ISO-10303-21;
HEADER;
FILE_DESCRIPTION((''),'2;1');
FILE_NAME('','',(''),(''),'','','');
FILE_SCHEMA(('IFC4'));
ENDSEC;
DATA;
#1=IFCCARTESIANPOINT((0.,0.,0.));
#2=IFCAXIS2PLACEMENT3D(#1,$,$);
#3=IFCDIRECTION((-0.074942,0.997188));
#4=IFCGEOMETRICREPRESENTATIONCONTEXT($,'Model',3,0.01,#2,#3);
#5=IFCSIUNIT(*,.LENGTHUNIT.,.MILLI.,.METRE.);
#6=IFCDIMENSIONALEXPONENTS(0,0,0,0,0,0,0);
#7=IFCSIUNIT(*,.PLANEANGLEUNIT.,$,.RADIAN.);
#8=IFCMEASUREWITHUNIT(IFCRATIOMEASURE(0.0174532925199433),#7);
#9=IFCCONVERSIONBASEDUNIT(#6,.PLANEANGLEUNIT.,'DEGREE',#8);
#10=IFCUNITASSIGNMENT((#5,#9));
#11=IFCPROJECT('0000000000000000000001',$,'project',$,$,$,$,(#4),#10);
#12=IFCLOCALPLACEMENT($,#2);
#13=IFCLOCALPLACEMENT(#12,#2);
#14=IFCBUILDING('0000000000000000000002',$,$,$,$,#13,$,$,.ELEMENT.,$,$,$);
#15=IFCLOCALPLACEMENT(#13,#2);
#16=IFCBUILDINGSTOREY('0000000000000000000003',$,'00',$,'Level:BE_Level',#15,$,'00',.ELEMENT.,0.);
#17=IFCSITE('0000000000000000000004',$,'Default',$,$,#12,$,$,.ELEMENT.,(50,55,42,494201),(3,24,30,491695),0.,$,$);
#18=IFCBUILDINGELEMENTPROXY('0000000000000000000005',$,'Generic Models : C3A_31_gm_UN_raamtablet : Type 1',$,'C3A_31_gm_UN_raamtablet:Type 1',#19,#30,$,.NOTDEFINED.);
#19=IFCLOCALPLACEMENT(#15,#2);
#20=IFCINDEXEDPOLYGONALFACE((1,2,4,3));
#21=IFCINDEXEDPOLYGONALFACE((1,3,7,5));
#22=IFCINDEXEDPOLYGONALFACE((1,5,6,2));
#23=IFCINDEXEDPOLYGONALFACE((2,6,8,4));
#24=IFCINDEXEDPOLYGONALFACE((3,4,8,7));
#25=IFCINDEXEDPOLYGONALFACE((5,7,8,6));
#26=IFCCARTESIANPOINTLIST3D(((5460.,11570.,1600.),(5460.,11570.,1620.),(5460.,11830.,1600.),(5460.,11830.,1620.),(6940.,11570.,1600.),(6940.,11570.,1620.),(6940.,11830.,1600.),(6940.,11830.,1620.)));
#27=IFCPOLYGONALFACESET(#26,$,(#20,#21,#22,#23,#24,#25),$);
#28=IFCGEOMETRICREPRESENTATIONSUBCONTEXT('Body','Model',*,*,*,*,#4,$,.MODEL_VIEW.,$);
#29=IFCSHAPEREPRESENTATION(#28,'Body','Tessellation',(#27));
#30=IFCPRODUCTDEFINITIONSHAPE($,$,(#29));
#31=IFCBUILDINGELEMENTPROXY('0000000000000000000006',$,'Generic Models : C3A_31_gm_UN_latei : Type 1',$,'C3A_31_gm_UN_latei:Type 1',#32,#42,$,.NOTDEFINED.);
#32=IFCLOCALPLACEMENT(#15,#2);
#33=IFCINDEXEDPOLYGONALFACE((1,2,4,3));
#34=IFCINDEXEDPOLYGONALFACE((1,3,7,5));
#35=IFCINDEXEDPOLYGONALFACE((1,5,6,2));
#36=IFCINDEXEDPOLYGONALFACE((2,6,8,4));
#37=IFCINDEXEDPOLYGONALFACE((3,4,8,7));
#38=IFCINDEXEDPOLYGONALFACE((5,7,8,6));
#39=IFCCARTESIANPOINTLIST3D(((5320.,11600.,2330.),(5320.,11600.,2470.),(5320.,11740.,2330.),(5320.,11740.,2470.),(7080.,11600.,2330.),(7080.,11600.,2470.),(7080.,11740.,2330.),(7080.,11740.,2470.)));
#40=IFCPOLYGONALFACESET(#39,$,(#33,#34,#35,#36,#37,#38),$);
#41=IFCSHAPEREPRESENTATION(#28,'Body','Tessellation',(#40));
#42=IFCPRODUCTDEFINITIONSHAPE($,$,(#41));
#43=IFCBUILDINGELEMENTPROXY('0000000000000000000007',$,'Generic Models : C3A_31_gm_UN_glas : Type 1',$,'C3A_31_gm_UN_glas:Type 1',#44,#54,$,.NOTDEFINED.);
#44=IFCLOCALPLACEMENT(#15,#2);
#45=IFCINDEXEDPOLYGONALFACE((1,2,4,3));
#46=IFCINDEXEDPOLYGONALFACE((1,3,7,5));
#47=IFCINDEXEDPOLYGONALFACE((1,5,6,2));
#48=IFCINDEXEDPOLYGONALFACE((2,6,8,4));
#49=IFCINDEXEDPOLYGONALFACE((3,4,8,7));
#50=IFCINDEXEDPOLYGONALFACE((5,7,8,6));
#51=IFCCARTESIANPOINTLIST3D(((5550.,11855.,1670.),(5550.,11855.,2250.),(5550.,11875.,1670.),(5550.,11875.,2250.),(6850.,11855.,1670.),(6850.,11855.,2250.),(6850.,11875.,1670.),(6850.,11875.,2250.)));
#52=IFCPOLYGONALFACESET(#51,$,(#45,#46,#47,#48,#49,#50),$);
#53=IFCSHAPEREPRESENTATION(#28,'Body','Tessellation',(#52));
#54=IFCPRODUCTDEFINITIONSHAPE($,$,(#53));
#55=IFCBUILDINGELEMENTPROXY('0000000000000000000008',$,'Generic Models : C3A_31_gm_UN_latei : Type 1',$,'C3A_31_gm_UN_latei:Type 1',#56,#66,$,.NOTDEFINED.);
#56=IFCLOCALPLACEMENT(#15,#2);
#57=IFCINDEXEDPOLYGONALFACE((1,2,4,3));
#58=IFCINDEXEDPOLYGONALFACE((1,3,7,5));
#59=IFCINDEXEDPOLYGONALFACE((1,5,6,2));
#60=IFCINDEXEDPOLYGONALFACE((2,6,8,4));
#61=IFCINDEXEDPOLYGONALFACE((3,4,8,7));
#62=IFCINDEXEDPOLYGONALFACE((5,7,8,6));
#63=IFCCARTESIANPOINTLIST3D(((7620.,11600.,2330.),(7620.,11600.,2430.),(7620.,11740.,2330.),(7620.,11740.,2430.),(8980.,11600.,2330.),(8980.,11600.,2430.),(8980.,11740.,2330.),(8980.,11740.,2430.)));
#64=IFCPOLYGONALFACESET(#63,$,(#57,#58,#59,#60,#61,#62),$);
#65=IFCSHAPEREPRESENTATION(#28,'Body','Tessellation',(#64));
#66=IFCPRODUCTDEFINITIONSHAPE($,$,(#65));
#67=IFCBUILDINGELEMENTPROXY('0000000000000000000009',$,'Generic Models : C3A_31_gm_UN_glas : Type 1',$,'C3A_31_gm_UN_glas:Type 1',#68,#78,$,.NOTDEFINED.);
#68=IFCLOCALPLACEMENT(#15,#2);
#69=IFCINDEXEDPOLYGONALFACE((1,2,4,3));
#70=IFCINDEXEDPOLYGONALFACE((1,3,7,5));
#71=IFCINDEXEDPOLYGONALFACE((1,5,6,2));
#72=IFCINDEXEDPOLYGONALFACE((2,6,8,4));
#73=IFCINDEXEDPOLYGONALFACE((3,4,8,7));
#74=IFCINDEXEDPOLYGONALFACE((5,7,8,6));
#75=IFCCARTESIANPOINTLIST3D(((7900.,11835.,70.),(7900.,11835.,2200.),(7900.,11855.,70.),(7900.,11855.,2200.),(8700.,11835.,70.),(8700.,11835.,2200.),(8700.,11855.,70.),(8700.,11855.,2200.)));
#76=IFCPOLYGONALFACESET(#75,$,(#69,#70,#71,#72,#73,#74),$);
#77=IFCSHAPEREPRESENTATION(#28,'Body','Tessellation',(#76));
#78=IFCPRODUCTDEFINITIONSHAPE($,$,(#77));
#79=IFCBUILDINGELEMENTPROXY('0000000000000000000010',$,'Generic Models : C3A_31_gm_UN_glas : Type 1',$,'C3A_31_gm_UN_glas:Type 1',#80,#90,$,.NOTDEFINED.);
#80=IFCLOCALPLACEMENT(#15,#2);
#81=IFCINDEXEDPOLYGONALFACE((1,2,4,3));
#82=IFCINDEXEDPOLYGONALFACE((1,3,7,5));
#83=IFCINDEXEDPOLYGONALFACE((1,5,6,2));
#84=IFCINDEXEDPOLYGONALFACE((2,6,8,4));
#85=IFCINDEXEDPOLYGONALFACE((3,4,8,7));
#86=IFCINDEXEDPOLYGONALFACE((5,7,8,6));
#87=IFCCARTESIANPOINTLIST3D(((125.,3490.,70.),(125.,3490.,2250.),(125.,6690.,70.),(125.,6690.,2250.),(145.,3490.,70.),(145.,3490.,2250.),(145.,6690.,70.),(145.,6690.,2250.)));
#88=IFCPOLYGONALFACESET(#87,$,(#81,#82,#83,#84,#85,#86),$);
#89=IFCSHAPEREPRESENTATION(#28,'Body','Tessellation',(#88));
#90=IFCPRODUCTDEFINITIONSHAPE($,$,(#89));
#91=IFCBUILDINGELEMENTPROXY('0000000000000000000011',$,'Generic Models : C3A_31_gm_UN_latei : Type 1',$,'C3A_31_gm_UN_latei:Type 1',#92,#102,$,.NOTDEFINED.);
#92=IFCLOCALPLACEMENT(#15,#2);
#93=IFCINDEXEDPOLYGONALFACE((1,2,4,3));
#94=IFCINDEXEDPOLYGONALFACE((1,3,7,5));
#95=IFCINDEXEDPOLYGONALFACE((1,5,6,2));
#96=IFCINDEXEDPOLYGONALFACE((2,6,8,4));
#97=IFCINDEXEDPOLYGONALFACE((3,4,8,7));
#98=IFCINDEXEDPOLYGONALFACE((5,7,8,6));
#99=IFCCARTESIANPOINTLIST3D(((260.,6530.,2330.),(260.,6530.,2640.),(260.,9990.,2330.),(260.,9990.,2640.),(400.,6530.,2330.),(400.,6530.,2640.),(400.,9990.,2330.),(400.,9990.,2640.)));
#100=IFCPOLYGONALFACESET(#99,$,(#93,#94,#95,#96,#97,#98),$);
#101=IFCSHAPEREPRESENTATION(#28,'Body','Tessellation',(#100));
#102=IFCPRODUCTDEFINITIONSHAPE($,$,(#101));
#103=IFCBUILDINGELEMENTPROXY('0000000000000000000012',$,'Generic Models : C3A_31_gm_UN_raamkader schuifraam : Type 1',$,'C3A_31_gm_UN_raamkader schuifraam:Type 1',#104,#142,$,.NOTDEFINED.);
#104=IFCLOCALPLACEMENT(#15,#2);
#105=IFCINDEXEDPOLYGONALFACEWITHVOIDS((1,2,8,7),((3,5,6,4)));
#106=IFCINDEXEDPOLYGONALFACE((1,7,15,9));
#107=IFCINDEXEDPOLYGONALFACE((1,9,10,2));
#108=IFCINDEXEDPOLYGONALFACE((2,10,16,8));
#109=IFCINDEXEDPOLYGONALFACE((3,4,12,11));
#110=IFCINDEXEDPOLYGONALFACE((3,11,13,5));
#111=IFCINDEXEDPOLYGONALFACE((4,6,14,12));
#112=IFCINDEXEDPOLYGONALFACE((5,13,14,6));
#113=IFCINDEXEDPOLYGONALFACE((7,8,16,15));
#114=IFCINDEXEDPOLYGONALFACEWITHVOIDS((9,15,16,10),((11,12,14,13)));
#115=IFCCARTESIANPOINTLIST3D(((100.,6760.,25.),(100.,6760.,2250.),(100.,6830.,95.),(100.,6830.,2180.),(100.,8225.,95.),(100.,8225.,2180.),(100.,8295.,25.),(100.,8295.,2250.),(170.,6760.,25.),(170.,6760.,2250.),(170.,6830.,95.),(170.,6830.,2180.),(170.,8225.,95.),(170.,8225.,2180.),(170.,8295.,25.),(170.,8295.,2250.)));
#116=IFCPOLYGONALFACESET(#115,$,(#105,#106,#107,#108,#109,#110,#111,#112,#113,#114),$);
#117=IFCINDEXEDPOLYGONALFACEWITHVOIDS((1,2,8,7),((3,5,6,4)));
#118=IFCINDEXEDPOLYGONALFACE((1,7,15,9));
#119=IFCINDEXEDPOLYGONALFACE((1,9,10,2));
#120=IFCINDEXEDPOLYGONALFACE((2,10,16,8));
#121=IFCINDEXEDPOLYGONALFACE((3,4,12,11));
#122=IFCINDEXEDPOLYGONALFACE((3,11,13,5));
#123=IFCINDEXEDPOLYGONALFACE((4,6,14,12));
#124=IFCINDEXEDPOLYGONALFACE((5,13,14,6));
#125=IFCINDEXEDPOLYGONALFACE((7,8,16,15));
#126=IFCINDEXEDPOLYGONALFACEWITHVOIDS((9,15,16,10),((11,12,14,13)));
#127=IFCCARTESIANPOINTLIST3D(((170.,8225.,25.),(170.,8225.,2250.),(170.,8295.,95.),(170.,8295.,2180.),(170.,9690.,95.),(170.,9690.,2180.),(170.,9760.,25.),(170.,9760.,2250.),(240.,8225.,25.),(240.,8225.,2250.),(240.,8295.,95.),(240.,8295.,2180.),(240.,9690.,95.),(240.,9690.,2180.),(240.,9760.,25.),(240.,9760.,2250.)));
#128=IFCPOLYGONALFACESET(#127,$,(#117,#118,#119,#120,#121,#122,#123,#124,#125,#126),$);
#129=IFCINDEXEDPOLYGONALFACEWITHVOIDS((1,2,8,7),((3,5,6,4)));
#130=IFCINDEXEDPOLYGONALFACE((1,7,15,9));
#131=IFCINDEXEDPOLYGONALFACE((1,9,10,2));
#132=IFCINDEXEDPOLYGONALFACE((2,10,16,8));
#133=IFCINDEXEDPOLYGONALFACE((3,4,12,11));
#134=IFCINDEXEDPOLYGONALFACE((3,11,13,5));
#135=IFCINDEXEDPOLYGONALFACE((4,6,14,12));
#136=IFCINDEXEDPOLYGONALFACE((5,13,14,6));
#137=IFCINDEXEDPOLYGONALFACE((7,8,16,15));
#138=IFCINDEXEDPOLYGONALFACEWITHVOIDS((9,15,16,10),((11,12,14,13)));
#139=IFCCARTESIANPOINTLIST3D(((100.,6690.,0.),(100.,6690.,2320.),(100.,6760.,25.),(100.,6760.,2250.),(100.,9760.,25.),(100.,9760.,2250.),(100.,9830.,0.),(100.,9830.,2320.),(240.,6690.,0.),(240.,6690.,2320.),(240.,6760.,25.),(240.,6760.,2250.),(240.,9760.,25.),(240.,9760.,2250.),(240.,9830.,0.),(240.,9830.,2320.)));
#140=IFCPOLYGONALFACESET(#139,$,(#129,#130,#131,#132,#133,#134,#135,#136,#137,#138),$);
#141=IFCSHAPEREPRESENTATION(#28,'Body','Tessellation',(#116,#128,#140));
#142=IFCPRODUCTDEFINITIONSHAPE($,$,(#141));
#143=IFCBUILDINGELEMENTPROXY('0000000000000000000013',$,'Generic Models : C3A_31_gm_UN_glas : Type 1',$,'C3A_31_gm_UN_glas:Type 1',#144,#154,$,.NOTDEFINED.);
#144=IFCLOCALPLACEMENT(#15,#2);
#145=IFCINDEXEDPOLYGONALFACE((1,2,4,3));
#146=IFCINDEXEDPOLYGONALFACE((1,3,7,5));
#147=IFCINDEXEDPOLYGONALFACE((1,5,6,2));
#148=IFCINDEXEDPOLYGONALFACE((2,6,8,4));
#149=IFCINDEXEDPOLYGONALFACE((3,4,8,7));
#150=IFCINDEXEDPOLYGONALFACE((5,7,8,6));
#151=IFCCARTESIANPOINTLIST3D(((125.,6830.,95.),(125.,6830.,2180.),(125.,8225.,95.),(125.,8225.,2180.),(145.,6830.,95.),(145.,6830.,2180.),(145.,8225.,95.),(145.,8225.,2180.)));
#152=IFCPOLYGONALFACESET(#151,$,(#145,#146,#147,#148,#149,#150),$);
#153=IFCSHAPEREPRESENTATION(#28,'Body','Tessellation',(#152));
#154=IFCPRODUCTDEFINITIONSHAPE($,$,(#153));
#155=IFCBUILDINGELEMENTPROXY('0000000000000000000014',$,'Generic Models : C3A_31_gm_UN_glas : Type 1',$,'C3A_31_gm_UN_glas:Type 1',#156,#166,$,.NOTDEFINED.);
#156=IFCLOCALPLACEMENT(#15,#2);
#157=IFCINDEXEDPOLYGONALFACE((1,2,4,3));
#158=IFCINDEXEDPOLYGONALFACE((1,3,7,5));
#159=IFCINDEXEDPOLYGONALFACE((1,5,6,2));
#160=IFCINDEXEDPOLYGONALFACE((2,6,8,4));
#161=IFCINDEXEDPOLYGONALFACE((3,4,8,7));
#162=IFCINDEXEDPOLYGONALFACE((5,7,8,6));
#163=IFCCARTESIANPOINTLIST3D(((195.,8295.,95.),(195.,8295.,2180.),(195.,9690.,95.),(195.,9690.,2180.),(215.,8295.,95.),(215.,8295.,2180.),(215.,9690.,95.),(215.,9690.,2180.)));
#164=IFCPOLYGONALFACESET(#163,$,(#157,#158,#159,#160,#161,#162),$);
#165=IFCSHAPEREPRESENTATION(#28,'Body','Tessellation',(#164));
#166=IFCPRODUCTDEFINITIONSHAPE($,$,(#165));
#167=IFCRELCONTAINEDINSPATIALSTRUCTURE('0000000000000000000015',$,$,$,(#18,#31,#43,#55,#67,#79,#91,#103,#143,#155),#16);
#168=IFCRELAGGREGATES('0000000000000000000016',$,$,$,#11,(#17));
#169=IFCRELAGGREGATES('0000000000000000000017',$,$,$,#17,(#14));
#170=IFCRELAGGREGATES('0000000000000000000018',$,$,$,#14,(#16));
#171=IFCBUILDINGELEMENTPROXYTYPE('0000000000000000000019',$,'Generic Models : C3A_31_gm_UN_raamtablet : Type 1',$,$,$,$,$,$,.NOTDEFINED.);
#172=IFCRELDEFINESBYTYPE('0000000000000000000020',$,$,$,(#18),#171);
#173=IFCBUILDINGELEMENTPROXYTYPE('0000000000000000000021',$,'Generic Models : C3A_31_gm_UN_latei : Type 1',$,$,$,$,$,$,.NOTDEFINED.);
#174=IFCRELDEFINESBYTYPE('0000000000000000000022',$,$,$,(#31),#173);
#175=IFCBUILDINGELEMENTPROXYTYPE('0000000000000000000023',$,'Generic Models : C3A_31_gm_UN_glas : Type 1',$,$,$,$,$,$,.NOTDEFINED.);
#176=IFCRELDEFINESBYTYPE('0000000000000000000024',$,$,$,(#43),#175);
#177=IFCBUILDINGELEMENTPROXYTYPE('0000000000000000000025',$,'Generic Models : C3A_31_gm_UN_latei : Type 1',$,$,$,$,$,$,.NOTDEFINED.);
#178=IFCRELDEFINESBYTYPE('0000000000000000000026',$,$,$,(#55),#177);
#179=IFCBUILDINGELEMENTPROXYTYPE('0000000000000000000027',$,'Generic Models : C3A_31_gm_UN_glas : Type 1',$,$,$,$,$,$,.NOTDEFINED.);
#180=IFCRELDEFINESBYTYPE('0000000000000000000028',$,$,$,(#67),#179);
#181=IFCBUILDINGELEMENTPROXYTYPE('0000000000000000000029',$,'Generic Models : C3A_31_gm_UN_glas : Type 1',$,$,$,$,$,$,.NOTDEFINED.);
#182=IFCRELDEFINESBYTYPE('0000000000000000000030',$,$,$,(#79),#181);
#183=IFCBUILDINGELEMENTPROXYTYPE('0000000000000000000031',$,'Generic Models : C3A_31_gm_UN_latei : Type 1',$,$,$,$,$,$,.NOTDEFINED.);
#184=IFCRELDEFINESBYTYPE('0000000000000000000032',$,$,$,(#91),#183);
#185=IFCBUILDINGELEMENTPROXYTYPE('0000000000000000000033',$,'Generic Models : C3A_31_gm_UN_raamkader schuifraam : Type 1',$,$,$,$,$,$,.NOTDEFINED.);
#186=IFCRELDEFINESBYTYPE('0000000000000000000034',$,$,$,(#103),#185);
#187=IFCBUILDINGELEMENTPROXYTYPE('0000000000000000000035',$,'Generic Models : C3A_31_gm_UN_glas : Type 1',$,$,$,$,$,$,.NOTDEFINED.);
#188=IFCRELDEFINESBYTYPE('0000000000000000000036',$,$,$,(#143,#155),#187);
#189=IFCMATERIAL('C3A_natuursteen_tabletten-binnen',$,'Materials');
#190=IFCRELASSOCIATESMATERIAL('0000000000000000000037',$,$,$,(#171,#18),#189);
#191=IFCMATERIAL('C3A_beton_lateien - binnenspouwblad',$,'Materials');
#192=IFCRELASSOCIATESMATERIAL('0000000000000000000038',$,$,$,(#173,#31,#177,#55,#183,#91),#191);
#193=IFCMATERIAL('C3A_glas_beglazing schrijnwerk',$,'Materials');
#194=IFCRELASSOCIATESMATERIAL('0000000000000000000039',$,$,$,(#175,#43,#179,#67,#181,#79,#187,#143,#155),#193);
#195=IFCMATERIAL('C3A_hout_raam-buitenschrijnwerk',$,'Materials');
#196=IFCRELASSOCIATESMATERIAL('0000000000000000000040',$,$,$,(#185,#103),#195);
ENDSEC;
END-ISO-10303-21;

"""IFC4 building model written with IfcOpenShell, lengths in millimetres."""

from ifc_helpers import new_model, entity, si_unit, converted_unit, direction, frame, origin, origin_2d_with_axis, place, context, subcontext, project, spatial, polyline, rectangle, outline, extrude, source, transform, mapped, material, type_object, type_shapes, element, save


model = new_model("IFC4")

# Units and contexts
model_context = context("Model", 3, precision=0.01, world=origin(), true_north=direction((-0.074942, 0.997188)))
body_context = subcontext(model_context, "Body", "Model", "MODEL_VIEW")
ifc_project = project(units=[si_unit("LENGTHUNIT", "METRE", prefix="MILLI"), converted_unit("PLANEANGLEUNIT", "DEGREE", entity("IfcRatioMeasure", 0.0174532925199433), si_unit("PLANEANGLEUNIT", "RADIAN"), dimensions=[0, 0, 0, 0, 0, 0, 0])], contexts=[model_context])

# Site, building, storey
site_placement = place(None, origin())
site = spatial("IfcSite", under=ifc_project, at=site_placement, Name="Default", CompositionType="ELEMENT", RefLatitude=(50, 55, 42, 494201), RefLongitude=(3, 24, 30, 491695), RefElevation=0.0)
building_placement = place(site_placement, origin())
building = spatial("IfcBuilding", under=site, at=building_placement, CompositionType="ELEMENT")
storey_placement = place(building_placement, frame((0.0, 0.0, 0.0)))
storey = spatial("IfcBuildingStorey", under=building, at=storey_placement, Name="00", ObjectType="Level:BE_Level", LongName="00", CompositionType="ELEMENT", Elevation=0.0)

# Building element proxies
ifc_material_1 = material(Name="C3A_natuursteen_tabletten-binnen", Category="Materials")
building_element_proxy_type_1 = type_object("IfcBuildingElementProxyType", Name="Generic Models : C3A_31_gm_UN_raamtablet : Type 1", PredefinedType="NOTDEFINED", material=ifc_material_1)
shared_shape_1 = source(origin(), body_context, "Body", "SweptSolid", [
    extrude(rectangle(XDim=1480.0, YDim=260.0, at=origin_2d_with_axis()), frame((0.0, 130.0, 0.0), z_axis=(0.0, 0.0, 1.0), x_axis=(-1.0, 0.0, 0.0)), (0.0, 0.0, 1.0), 20.0),
])
type_shapes(building_element_proxy_type_1, [shared_shape_1])
proxy_1_placement = place(storey_placement, frame((6200.0, 11570.0, 1600.0)))
element("IfcBuildingElementProxy", 1, at=proxy_1_placement, inside=storey, type_object=building_element_proxy_type_1, material=ifc_material_1, Name="Generic Models : C3A_31_gm_UN_raamtablet : Type 1", ObjectType="C3A_31_gm_UN_raamtablet:Type 1", PredefinedType="NOTDEFINED", context=body_context, shape_type="MappedRepresentation", body=[
    mapped(shared_shape_1, transform((0.0, 0.0, 0.0), scale=1.0)),
])
ifc_material_2 = material(Name="C3A_beton_lateien - binnenspouwblad", Category="Materials")
building_element_proxy_type_2 = type_object("IfcBuildingElementProxyType", Name="Generic Models : C3A_31_gm_UN_latei : Type 1", PredefinedType="NOTDEFINED", material=ifc_material_2)
shared_shape_2 = source(origin(), body_context, "Body", "SweptSolid", [
    extrude(rectangle(XDim=1760.0, YDim=140.0, at=origin_2d_with_axis()), frame((0.0, 70.0, 0.0), z_axis=(0.0, 0.0, 1.0), x_axis=(-1.0, 0.0, 0.0)), (0.0, 0.0, 1.0), 140.0),
])
type_shapes(building_element_proxy_type_2, [shared_shape_2])
proxy_2_placement = place(storey_placement, frame((6200.0, 11600.0, 2330.0)))
element("IfcBuildingElementProxy", 2, at=proxy_2_placement, inside=storey, type_object=building_element_proxy_type_2, material=ifc_material_2, Name="Generic Models : C3A_31_gm_UN_latei : Type 1", ObjectType="C3A_31_gm_UN_latei:Type 1", PredefinedType="NOTDEFINED", context=body_context, shape_type="MappedRepresentation", body=[
    mapped(shared_shape_2, transform((0.0, 0.0, 0.0), scale=1.0)),
])
ifc_material_3 = material(Name="C3A_hout_raam-buitenschrijnwerk", Category="Materials")
ifc_material_4 = material(Name="C3A_glas_beglazing schrijnwerk", Category="Materials")
building_element_proxy_type_3 = type_object("IfcBuildingElementProxyType", Name="Generic Models : C3A_31_gm_UN_glas : Type 1", PredefinedType="NOTDEFINED", material=ifc_material_4)
shared_shape_3 = source(origin(), body_context, "Body", "SweptSolid", [
    extrude(rectangle(XDim=1300.0, YDim=20.0, at=origin_2d_with_axis()), frame((650.0, 10.0, 0.0), z_axis=(0.0, 0.0, 1.0), x_axis=(-1.0, 0.0, 0.0)), (0.0, 0.0, 1.0), 580.0),
])
type_shapes(building_element_proxy_type_3, [shared_shape_3])
proxy_3_placement = place(storey_placement, frame((5550.0, 11855.0, 1670.0)))
element("IfcBuildingElementProxy", 3, at=proxy_3_placement, inside=storey, type_object=building_element_proxy_type_3, material=ifc_material_4, Name="Generic Models : C3A_31_gm_UN_glas : Type 1", ObjectType="C3A_31_gm_UN_glas:Type 1", PredefinedType="NOTDEFINED", context=body_context, shape_type="MappedRepresentation", body=[
    mapped(shared_shape_3, transform((0.0, 0.0, 0.0), scale=1.0)),
])
building_element_proxy_type_4 = type_object("IfcBuildingElementProxyType", Name="Generic Models : C3A_31_gm_UN_latei : Type 1", PredefinedType="NOTDEFINED", material=ifc_material_2)
shared_shape_4 = source(origin(), body_context, "Body", "SweptSolid", [
    extrude(rectangle(XDim=1360.0, YDim=140.0, at=origin_2d_with_axis()), frame((0.0, 70.0, 0.0), z_axis=(0.0, 0.0, 1.0), x_axis=(-1.0, 0.0, 0.0)), (0.0, 0.0, 1.0), 100.0),
])
type_shapes(building_element_proxy_type_4, [shared_shape_4])
proxy_4_placement = place(storey_placement, frame((8300.0, 11600.0, 2330.0)))
element("IfcBuildingElementProxy", 4, at=proxy_4_placement, inside=storey, type_object=building_element_proxy_type_4, material=ifc_material_2, Name="Generic Models : C3A_31_gm_UN_latei : Type 1", ObjectType="C3A_31_gm_UN_latei:Type 1", PredefinedType="NOTDEFINED", context=body_context, shape_type="MappedRepresentation", body=[
    mapped(shared_shape_4, transform((0.0, 0.0, 0.0), scale=1.0)),
])
building_element_proxy_type_5 = type_object("IfcBuildingElementProxyType", Name="Generic Models : C3A_31_gm_UN_glas : Type 1", PredefinedType="NOTDEFINED", material=ifc_material_4)
shared_shape_5 = source(origin(), body_context, "Body", "SweptSolid", [
    extrude(rectangle(XDim=800.0, YDim=20.0, at=origin_2d_with_axis()), frame((400.0, 10.0, 0.0), z_axis=(0.0, 0.0, 1.0), x_axis=(-1.0, 0.0, 0.0)), (0.0, 0.0, 1.0), 2130.0),
])
type_shapes(building_element_proxy_type_5, [shared_shape_5])
proxy_5_placement = place(storey_placement, frame((7900.0, 11835.0, 70.0)))
element("IfcBuildingElementProxy", 5, at=proxy_5_placement, inside=storey, type_object=building_element_proxy_type_5, material=ifc_material_4, Name="Generic Models : C3A_31_gm_UN_glas : Type 1", ObjectType="C3A_31_gm_UN_glas:Type 1", PredefinedType="NOTDEFINED", context=body_context, shape_type="MappedRepresentation", body=[
    mapped(shared_shape_5, transform((0.0, 0.0, 0.0), scale=1.0)),
])
building_element_proxy_type_6 = type_object("IfcBuildingElementProxyType", Name="Generic Models : C3A_31_gm_UN_glas : Type 1", PredefinedType="NOTDEFINED", material=ifc_material_4)
shared_shape_6 = source(origin(), body_context, "Body", "SweptSolid", [
    extrude(rectangle(XDim=20.0, YDim=3200.0, at=origin_2d_with_axis()), frame((1600.0, 10.0, 0.0), z_axis=(0.0, 0.0, 1.0), x_axis=(0.0, 1.0, 0.0)), (0.0, 0.0, 1.0), 2180.0),
])
type_shapes(building_element_proxy_type_6, [shared_shape_6])
proxy_6_placement = place(storey_placement, frame((125.0, 6690.0, 70.0), z_axis=(0.0, 0.0, 1.0), x_axis=(0.0, -1.0, 0.0)))
element("IfcBuildingElementProxy", 6, at=proxy_6_placement, inside=storey, type_object=building_element_proxy_type_6, material=ifc_material_4, Name="Generic Models : C3A_31_gm_UN_glas : Type 1", ObjectType="C3A_31_gm_UN_glas:Type 1", PredefinedType="NOTDEFINED", context=body_context, shape_type="MappedRepresentation", body=[
    mapped(shared_shape_6, transform((0.0, 0.0, 0.0), scale=1.0)),
])
building_element_proxy_type_7 = type_object("IfcBuildingElementProxyType", Name="Generic Models : C3A_31_gm_UN_latei : Type 1", PredefinedType="NOTDEFINED", material=ifc_material_2)
shared_shape_7 = source(origin(), body_context, "Body", "SweptSolid", [
    extrude(rectangle(XDim=3460.0, YDim=140.0, at=origin_2d_with_axis()), frame((0.0, 70.0, 0.0), z_axis=(0.0, 0.0, 1.0), x_axis=(-1.0, 0.0, 0.0)), (0.0, 0.0, 1.0), 310.0),
])
type_shapes(building_element_proxy_type_7, [shared_shape_7])
proxy_7_placement = place(storey_placement, frame((400.0, 8260.0, 2330.0), z_axis=(0.0, 0.0, 1.0), x_axis=(0.0, 1.0, 0.0)))
element("IfcBuildingElementProxy", 7, at=proxy_7_placement, inside=storey, type_object=building_element_proxy_type_7, material=ifc_material_2, Name="Generic Models : C3A_31_gm_UN_latei : Type 1", ObjectType="C3A_31_gm_UN_latei:Type 1", PredefinedType="NOTDEFINED", context=body_context, shape_type="MappedRepresentation", body=[
    mapped(shared_shape_7, transform((0.0, 0.0, 0.0), scale=1.0)),
])
building_element_proxy_type_8 = type_object("IfcBuildingElementProxyType", Name="Generic Models : C3A_31_gm_UN_raamkader schuifraam : Type 1", PredefinedType="NOTDEFINED", material=ifc_material_3)
shared_shape_8 = source(origin(), body_context, "Body", "SweptSolid", [
    extrude(outline(polyline([(-767.5, -1112.5), (767.5, -1112.5), (767.5, 1112.5), (-767.5, 1112.5), (-767.5, -1112.5)]), holes=[polyline([(697.5, -1042.5), (-697.5, -1042.5), (-697.5, 1042.5), (697.5, 1042.5), (697.5, -1042.5)])]), frame((0.0, 837.5, 1137.5), z_axis=(1.0, 0.0, 0.0), x_axis=(0.0, 1.0, 0.0)), (0.0, 0.0, 1.0), 70.0),
    extrude(outline(polyline([(-1112.5, -767.5), (1112.5, -767.5), (1112.5, 767.5), (-1112.5, 767.5), (-1112.5, -767.5)]), holes=[polyline([(1042.5, -697.5), (-1042.5, -697.5), (-1042.5, 697.5), (1042.5, 697.5), (1042.5, -697.5)])]), frame((70.0, 2302.5, 1137.5), z_axis=(1.0, 0.0, 0.0), x_axis=(0.0, 0.0, 1.0)), (0.0, 0.0, 1.0), 70.0),
    extrude(outline(polyline([(-1570.0, -1160.0), (1570.0, -1160.0), (1570.0, 1160.0), (-1570.0, 1160.0), (-1570.0, -1160.0)]), holes=[polyline([(-1500.0, 1135.0), (1500.0, 1135.0), (1500.0, -1090.0), (-1500.0, -1090.0), (-1500.0, 1135.0)])]), frame((0.0, 1570.0, 1160.0), z_axis=(1.0, 0.0, 0.0), x_axis=(0.0, -1.0, 0.0)), (0.0, 0.0, 1.0), 140.0),
])
type_shapes(building_element_proxy_type_8, [shared_shape_8])
proxy_8_placement = place(storey_placement, frame((100.0, 6690.0, 0.0)))
element("IfcBuildingElementProxy", 8, at=proxy_8_placement, inside=storey, type_object=building_element_proxy_type_8, material=ifc_material_3, Name="Generic Models : C3A_31_gm_UN_raamkader schuifraam : Type 1", ObjectType="C3A_31_gm_UN_raamkader schuifraam:Type 1", PredefinedType="NOTDEFINED", context=body_context, shape_type="MappedRepresentation", body=[
    mapped(shared_shape_8, transform((0.0, 0.0, 0.0), scale=1.0)),
])
building_element_proxy_type_9 = type_object("IfcBuildingElementProxyType", Name="Generic Models : C3A_31_gm_UN_glas : Type 1", PredefinedType="NOTDEFINED", material=ifc_material_4)
shared_shape_9 = source(origin(), body_context, "Body", "SweptSolid", [
    extrude(rectangle(XDim=20.0, YDim=1395.0, at=origin_2d_with_axis()), frame((697.5, 10.0, 0.0), z_axis=(0.0, 0.0, 1.0), x_axis=(0.0, 1.0, 0.0)), (0.0, 0.0, 1.0), 2085.0),
])
type_shapes(building_element_proxy_type_9, [shared_shape_9])
for number, where, z_axis, x_axis, name in (
    (9, (125.0, 8225.0, 95.0), (0.0, 0.0, 1.0), (0.0, -1.0, 0.0), "Generic Models : C3A_31_gm_UN_glas : Type 1"),
    (10, (195.0, 9690.0, 95.0), (0.0, 0.0, 1.0), (0.0, -1.0, 0.0), "Generic Models : C3A_31_gm_UN_glas : Type 1"),
):
    element("IfcBuildingElementProxy", number, at=place(storey_placement, frame(where, z_axis=z_axis, x_axis=x_axis)), inside=storey, type_object=building_element_proxy_type_9, material=ifc_material_4, Name=name, ObjectType="C3A_31_gm_UN_glas:Type 1", PredefinedType="NOTDEFINED", context=body_context, shape_type="MappedRepresentation", body=[
        mapped(shared_shape_9, transform((0.0, 0.0, 0.0), scale=1.0)),
    ])

save(model, "model.ifc")
